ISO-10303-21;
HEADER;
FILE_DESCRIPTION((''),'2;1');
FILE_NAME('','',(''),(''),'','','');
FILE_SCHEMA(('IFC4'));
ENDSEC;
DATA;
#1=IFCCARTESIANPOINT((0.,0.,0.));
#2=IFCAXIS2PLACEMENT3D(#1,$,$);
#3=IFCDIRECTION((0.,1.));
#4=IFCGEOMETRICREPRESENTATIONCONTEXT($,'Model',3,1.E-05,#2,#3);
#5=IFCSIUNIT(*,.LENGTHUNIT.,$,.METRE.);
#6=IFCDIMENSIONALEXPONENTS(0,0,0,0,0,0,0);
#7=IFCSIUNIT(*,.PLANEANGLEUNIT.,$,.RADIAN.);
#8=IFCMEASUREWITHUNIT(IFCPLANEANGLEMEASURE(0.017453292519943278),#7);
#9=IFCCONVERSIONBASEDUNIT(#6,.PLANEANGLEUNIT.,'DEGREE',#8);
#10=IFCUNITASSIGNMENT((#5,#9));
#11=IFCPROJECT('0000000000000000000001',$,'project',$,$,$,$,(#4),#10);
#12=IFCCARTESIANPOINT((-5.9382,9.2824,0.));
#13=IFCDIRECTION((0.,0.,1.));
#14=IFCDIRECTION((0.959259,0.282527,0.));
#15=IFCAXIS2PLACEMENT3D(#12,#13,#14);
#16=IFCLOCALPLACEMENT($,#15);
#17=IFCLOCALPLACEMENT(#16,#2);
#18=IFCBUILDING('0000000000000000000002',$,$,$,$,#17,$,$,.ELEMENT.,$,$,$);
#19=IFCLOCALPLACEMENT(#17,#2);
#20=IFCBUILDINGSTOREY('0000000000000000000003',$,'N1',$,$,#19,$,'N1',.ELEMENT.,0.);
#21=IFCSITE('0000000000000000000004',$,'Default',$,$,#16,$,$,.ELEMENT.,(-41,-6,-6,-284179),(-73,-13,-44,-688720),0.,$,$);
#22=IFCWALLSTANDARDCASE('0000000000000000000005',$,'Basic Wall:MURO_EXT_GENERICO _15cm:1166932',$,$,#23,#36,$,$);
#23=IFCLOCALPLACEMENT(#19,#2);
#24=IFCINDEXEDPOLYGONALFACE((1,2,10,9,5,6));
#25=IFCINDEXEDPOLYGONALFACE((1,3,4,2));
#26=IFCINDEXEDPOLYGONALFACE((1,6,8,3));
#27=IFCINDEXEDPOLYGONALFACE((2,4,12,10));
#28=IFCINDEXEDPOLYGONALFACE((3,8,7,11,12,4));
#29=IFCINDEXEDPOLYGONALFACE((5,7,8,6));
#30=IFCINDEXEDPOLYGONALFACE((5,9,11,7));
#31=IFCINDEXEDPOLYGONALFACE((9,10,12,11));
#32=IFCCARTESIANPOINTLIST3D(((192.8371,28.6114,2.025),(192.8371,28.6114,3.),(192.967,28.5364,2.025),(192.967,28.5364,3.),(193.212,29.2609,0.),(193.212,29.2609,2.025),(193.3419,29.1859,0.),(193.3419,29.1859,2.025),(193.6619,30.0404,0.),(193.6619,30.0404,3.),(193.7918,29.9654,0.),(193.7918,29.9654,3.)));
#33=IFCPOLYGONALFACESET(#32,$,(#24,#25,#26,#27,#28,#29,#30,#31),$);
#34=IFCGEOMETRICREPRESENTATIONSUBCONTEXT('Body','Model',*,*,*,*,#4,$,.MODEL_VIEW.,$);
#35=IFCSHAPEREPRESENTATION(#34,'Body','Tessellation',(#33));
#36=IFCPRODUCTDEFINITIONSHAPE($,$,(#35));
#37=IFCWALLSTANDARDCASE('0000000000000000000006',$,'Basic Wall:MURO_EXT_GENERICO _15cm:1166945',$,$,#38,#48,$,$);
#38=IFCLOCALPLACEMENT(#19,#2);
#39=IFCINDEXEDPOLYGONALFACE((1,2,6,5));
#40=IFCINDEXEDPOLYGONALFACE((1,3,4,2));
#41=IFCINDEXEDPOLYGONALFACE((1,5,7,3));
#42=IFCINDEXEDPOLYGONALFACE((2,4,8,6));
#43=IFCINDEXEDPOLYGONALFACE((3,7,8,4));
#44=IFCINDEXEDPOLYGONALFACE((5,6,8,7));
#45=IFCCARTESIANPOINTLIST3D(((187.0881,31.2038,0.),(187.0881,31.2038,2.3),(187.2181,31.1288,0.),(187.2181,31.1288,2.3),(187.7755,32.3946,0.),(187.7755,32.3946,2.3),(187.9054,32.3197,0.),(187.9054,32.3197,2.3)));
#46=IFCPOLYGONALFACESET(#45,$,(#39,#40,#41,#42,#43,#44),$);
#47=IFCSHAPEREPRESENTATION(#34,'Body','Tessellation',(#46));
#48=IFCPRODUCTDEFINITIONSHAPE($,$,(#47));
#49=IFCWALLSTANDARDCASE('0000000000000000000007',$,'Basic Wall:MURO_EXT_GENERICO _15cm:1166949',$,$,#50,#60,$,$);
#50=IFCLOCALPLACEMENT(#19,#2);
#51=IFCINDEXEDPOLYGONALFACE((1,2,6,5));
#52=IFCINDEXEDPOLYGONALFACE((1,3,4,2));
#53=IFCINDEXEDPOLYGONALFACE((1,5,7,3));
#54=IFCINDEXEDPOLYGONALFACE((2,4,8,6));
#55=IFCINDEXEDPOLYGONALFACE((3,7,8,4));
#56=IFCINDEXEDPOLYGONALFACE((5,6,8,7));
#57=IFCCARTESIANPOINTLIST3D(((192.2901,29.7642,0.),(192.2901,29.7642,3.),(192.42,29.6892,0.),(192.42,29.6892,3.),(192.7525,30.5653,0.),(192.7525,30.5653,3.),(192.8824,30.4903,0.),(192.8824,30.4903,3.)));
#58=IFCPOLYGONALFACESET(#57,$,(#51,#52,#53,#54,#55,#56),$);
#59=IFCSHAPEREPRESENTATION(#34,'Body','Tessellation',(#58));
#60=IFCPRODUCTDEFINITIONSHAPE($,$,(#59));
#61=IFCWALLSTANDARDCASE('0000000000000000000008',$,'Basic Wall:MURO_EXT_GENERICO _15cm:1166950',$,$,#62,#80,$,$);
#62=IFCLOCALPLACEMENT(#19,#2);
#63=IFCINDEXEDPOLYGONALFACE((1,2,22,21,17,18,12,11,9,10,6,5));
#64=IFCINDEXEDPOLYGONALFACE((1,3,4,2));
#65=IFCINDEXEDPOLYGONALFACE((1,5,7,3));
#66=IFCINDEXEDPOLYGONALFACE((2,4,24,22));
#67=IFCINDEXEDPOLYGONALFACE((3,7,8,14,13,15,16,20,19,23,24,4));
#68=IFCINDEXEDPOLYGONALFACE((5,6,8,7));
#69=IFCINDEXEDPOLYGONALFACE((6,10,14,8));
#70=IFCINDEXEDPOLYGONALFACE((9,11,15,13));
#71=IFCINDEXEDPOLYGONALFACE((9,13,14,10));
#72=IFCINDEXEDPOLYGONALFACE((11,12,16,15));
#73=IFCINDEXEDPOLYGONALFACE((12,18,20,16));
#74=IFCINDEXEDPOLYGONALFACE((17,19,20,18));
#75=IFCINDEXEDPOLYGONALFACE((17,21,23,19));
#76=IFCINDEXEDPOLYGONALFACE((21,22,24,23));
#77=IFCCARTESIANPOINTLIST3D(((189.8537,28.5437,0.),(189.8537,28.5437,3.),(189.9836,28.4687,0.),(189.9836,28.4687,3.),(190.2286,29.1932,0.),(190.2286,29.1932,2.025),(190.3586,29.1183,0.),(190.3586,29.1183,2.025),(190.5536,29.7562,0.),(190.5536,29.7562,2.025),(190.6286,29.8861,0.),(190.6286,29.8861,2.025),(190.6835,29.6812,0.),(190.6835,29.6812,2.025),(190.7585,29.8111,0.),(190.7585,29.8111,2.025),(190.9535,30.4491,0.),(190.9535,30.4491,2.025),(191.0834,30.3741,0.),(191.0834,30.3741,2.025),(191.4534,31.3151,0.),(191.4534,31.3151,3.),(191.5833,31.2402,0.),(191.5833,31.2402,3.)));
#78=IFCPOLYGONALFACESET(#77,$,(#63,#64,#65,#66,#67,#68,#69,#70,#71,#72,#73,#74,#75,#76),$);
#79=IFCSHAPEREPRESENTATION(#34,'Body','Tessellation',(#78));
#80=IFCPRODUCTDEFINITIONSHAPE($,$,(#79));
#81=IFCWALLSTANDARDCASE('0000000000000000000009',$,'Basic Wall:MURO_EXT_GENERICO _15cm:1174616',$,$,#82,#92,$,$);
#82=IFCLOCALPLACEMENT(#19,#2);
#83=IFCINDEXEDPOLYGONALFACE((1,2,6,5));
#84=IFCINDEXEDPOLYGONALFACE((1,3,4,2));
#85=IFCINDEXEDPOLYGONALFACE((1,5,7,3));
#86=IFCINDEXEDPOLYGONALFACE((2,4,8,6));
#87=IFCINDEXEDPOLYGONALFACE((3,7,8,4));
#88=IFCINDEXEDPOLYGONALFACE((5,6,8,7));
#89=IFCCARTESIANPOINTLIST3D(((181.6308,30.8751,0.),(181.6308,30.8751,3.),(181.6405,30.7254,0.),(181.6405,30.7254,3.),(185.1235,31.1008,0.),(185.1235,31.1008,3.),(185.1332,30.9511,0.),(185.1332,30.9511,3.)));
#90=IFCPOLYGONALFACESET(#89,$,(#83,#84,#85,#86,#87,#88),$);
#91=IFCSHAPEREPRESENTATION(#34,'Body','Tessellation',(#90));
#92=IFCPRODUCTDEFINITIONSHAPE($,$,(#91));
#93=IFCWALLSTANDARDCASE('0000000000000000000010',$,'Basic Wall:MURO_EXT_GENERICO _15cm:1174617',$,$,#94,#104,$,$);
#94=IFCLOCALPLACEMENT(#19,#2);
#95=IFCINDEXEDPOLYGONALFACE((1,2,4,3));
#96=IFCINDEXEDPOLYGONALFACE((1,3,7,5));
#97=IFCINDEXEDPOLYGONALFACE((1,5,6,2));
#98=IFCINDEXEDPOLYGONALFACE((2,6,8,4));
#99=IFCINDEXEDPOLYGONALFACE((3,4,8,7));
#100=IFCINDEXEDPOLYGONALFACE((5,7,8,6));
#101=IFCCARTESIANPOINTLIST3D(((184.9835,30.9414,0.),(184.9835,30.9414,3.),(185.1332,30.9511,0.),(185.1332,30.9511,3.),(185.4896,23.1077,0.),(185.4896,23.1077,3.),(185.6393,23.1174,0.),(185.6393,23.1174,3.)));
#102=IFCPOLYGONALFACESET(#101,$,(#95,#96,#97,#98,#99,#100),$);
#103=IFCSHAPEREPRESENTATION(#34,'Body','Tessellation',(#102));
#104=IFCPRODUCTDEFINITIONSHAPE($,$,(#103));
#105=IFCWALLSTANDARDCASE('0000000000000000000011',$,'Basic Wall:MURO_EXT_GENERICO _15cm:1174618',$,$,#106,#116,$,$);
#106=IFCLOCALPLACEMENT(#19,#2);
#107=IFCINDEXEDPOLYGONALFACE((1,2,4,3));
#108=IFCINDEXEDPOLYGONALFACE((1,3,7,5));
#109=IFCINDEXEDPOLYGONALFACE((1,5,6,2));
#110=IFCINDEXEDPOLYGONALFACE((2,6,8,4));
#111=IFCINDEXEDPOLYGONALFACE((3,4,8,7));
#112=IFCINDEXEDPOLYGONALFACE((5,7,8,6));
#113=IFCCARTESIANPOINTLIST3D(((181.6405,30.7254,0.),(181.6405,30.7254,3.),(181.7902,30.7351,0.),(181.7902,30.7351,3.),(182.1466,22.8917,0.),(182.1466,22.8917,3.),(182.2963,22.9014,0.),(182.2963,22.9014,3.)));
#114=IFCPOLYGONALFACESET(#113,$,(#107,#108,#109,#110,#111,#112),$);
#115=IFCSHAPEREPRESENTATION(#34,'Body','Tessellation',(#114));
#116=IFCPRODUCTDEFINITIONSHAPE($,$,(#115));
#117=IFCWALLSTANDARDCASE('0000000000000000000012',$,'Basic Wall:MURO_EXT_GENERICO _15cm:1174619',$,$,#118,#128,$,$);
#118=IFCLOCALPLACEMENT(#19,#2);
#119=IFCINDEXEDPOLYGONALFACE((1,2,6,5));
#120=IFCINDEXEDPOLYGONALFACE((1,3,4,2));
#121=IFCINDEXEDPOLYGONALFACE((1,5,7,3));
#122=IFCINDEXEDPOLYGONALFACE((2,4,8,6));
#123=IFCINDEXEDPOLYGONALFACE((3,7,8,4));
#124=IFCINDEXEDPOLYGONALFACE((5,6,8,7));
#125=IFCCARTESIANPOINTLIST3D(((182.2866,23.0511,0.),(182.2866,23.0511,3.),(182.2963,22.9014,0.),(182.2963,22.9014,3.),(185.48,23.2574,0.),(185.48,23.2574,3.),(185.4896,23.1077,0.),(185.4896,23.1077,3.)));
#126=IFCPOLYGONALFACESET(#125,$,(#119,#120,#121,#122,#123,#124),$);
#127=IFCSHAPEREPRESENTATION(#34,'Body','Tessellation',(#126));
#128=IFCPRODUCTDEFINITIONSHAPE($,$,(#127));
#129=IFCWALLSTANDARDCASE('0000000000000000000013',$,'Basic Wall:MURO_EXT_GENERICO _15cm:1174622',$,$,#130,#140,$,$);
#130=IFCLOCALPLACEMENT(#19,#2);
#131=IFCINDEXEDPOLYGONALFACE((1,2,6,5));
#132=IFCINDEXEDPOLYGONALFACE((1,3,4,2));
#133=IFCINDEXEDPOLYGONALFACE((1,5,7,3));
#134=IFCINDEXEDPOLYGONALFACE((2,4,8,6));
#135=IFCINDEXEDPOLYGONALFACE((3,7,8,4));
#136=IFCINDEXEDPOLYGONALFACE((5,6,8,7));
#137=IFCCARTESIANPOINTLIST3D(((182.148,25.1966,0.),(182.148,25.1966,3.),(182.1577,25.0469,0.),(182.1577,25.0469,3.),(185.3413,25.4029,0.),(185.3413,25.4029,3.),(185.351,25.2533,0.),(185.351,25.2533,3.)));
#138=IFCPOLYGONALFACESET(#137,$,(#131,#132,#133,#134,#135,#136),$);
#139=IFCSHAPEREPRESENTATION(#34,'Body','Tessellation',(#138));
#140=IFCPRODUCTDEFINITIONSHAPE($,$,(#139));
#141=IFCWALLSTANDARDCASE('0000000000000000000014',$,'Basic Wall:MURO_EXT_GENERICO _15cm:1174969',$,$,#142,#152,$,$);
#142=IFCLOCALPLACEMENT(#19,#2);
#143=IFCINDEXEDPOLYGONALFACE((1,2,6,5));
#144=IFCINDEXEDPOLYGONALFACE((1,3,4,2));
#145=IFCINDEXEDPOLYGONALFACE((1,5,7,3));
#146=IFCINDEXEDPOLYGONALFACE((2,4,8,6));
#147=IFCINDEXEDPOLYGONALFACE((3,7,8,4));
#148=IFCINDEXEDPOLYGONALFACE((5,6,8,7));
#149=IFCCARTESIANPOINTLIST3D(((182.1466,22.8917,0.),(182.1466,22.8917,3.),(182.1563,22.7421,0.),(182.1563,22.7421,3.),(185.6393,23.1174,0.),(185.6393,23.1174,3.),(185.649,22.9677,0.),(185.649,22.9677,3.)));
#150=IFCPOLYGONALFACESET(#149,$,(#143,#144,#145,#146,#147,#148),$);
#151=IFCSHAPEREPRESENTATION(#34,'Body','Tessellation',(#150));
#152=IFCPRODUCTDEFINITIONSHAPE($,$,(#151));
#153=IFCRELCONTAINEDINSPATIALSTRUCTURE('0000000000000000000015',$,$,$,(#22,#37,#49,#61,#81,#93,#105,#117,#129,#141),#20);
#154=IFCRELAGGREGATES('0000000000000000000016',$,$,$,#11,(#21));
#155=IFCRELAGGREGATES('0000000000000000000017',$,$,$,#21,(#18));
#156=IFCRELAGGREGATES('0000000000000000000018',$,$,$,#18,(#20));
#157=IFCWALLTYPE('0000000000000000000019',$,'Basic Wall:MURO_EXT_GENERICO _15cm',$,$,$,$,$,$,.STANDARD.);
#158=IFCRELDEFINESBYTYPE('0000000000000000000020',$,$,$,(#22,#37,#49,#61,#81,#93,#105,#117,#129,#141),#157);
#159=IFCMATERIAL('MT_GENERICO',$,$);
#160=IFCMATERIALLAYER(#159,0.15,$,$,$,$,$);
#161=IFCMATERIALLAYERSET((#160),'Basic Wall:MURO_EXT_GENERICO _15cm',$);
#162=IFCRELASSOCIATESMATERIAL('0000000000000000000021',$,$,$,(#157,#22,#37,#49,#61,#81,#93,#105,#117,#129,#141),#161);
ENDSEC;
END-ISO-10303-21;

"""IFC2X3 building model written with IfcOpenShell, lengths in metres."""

from ifc_helpers import new_model, entity, si_unit, converted_unit, direction, frame, frame_2d, origin, place, context, subcontext, project, spatial, rectangle, extrude, material, layer, layer_set, layer_usage, type_object, element, save


model = new_model("IFC2X3")

# Units and contexts
model_context = context("Model", 3, precision=1e-05, world=origin(), true_north=direction((0.0, 1.0)))
body_context = subcontext(model_context, "Body", "Model", "MODEL_VIEW")
ifc_project = project(units=[si_unit("LENGTHUNIT", "METRE"), converted_unit("PLANEANGLEUNIT", "DEGREE", entity("IfcPlaneAngleMeasure", 0.017453292519943278), si_unit("PLANEANGLEUNIT", "RADIAN"), dimensions=[0, 0, 0, 0, 0, 0, 0])], contexts=[model_context])

# Site, building, storey
site_placement = place(None, frame((-5.9382, 9.2824, 0.0), z_axis=(0.0, 0.0, 1.0), x_axis=(0.959259, 0.282527, 0.0)))
site = spatial("IfcSite", under=ifc_project, at=site_placement, Name="Default", CompositionType="ELEMENT", RefLatitude=(-41, -6, -6, -284179), RefLongitude=(-73, -13, -44, -688720), RefElevation=0.0)
building_placement = place(site_placement, origin())
building = spatial("IfcBuilding", under=site, at=building_placement, CompositionType="ELEMENT")
storey_placement = place(building_placement, origin())
storey = spatial("IfcBuildingStorey", under=building, at=storey_placement, Name="N1", LongName="N1", CompositionType="ELEMENT", Elevation=0.0)

# Shared definitions
ifc_material_1 = material(Name="MT_GENERICO")

# Shared definitions
ifc_layer_1 = layer(ifc_material_1, 0.15)
ifc_layer_set_1 = layer_set([ifc_layer_1], Name="Basic Wall:MURO_EXT_GENERICO _15cm")
wall_type_1 = type_object("IfcWallType", Name="Basic Wall:MURO_EXT_GENERICO _15cm", PredefinedType="STANDARD", material=ifc_layer_set_1)

# Wall, opening
ifc_layer_usage_1 = layer_usage(ifc_layer_set_1, "AXIS2", "NEGATIVE", 0.075)
wall_1_placement = place(storey_placement, frame((192.902, 28.5739, 0.0), z_axis=(0.0, 0.0, 1.0), x_axis=(0.499903, 0.866082, 0.0)))
wall_1 = element("IfcWallStandardCase", 1, at=wall_1_placement, inside=storey, type_object=wall_type_1, material=ifc_layer_usage_1, Name="Basic Wall:MURO_EXT_GENERICO _15cm:1166932", context=body_context, shape_type="SweptSolid", body=[
    extrude(rectangle(XDim=1.65, YDim=0.15, at=frame_2d((0.825, 0.0), x_axis=(-1.0, 0.0))), origin(), (0.0, 0.0, 1.0), 3.0),
])
opening_1_placement = place(wall_1_placement, frame((0.0, -0.075, 0.0)))
element("IfcOpeningElement", 2, at=opening_1_placement, cuts=wall_1, ObjectType="Opening", context=body_context, shape_type="SweptSolid", body=[
    extrude(rectangle(XDim=2.025, YDim=0.75, at=frame_2d((1.0125, 0.375), x_axis=(1.0, 0.0))), frame((0.0, 0.0, 0.0), z_axis=(0.0, 1.0, 0.0), x_axis=(0.0, 0.0, 1.0)), (0.0, 0.0, 1.0), 0.15),
])

# Walls
ifc_layer_usage_2 = layer_usage(ifc_layer_set_1, "AXIS2", "NEGATIVE", 0.075)
wall_2_placement = place(storey_placement, frame((187.1531, 31.1663, 0.0), z_axis=(0.0, 0.0, 1.0), x_axis=(0.499903, 0.866082, 0.0)))
element("IfcWallStandardCase", 3, at=wall_2_placement, inside=storey, type_object=wall_type_1, material=ifc_layer_usage_2, Name="Basic Wall:MURO_EXT_GENERICO _15cm:1166945", context=body_context, shape_type="SweptSolid", body=[
    extrude(rectangle(XDim=1.375, YDim=0.15, at=frame_2d((0.6875, 0.0), x_axis=(-1.0, 0.0))), origin(), (0.0, 0.0, 1.0), 2.3),
])
ifc_layer_usage_3 = layer_usage(ifc_layer_set_1, "AXIS2", "NEGATIVE", 0.075)
wall_3_placement = place(storey_placement, frame((192.8175, 30.5278, 0.0), z_axis=(0.0, 0.0, 1.0), x_axis=(-0.499903, -0.866082, 0.0)))
element("IfcWallStandardCase", 4, at=wall_3_placement, inside=storey, type_object=wall_type_1, material=ifc_layer_usage_3, Name="Basic Wall:MURO_EXT_GENERICO _15cm:1166949", context=body_context, shape_type="SweptSolid", body=[
    extrude(rectangle(XDim=0.925, YDim=0.15, at=frame_2d((0.4625, 0.0), x_axis=(-1.0, 0.0))), origin(), (0.0, 0.0, 1.0), 3.0),
])

# Wall, openings
ifc_layer_usage_4 = layer_usage(ifc_layer_set_1, "AXIS2", "NEGATIVE", 0.075)
wall_4_placement = place(storey_placement, frame((191.5184, 31.2777, 0.0), z_axis=(0.0, 0.0, 1.0), x_axis=(-0.499903, -0.866082, 0.0)))
wall_4 = element("IfcWallStandardCase", 5, at=wall_4_placement, inside=storey, type_object=wall_type_1, material=ifc_layer_usage_4, Name="Basic Wall:MURO_EXT_GENERICO _15cm:1166950", context=body_context, shape_type="SweptSolid", body=[
    extrude(rectangle(XDim=3.2, YDim=0.15, at=frame_2d((1.6, 0.0), x_axis=(-1.0, 0.0))), origin(), (0.0, 0.0, 1.0), 3.0),
])
opening_2_placement = place(wall_4_placement, frame((1.0, -0.075, 0.0)))
element("IfcOpeningElement", 6, at=opening_2_placement, cuts=wall_4, ObjectType="Opening", context=body_context, shape_type="SweptSolid", body=[
    extrude(rectangle(XDim=2.025, YDim=0.65, at=frame_2d((1.0125, 0.325), x_axis=(1.0, 0.0))), frame((0.0, 0.0, 0.0), z_axis=(0.0, 1.0, 0.0), x_axis=(0.0, 0.0, 1.0)), (0.0, 0.0, 1.0), 0.15),
])
opening_3_placement = place(wall_4_placement, frame((1.8, -0.075, 0.0)))
element("IfcOpeningElement", 7, at=opening_3_placement, cuts=wall_4, ObjectType="Opening", context=body_context, shape_type="SweptSolid", body=[
    extrude(rectangle(XDim=2.025, YDim=0.65, at=frame_2d((1.0125, 0.325), x_axis=(1.0, 0.0))), frame((0.0, 0.0, 0.0), z_axis=(0.0, 1.0, 0.0), x_axis=(0.0, 0.0, 1.0)), (0.0, 0.0, 1.0), 0.15),
])

# Walls
ifc_layer_usage_5 = layer_usage(ifc_layer_set_1, "AXIS2", "POSITIVE", -0.075)
wall_5_placement = place(storey_placement, frame((181.6357, 30.8003, 0.0), z_axis=(0.0, 0.0, 1.0), x_axis=(0.99792, 0.064471, 0.0)))
element("IfcWallStandardCase", 8, at=wall_5_placement, inside=storey, type_object=wall_type_1, material=ifc_layer_usage_5, Name="Basic Wall:MURO_EXT_GENERICO _15cm:1174616", context=body_context, shape_type="SweptSolid", body=[
    extrude(rectangle(XDim=3.5, YDim=0.15, at=frame_2d((1.75, 0.0), x_axis=(-1.0, 0.0))), origin(), (0.0, 0.0, 1.0), 3.0),
])
ifc_layer_usage_6 = layer_usage(ifc_layer_set_1, "AXIS2", "POSITIVE", -0.075)
wall_6_placement = place(storey_placement, frame((185.0584, 30.9462, 0.0), z_axis=(0.0, 0.0, 1.0), x_axis=(0.064471, -0.99792, 0.0)))
element("IfcWallStandardCase", 9, at=wall_6_placement, inside=storey, type_object=wall_type_1, material=ifc_layer_usage_6, Name="Basic Wall:MURO_EXT_GENERICO _15cm:1174617", context=body_context, shape_type="SweptSolid", body=[
    extrude(rectangle(XDim=7.85, YDim=0.15, at=frame_2d((3.925, 0.0), x_axis=(-1.0, 0.0))), origin(), (0.0, 0.0, 1.0), 3.0),
])
ifc_layer_usage_7 = layer_usage(ifc_layer_set_1, "AXIS2", "POSITIVE", -0.075)
wall_7_placement = place(storey_placement, frame((182.2214, 22.8966, 0.0), z_axis=(0.0, 0.0, 1.0), x_axis=(-0.064471, 0.99792, 0.0)))
element("IfcWallStandardCase", 10, at=wall_7_placement, inside=storey, type_object=wall_type_1, material=ifc_layer_usage_7, Name="Basic Wall:MURO_EXT_GENERICO _15cm:1174618", context=body_context, shape_type="SweptSolid", body=[
    extrude(rectangle(XDim=7.85, YDim=0.15, at=frame_2d((3.925, 0.0), x_axis=(-1.0, 0.0))), origin(), (0.0, 0.0, 1.0), 3.0),
])
ifc_layer_usage_8 = layer_usage(ifc_layer_set_1, "AXIS2", "POSITIVE", -0.075)
wall_8_placement = place(storey_placement, frame((185.4848, 23.1826, 0.0), z_axis=(0.0, 0.0, 1.0), x_axis=(-0.99792, -0.064471, 0.0)))
element("IfcWallStandardCase", 11, at=wall_8_placement, inside=storey, type_object=wall_type_1, material=ifc_layer_usage_8, Name="Basic Wall:MURO_EXT_GENERICO _15cm:1174619", context=body_context, shape_type="SweptSolid", body=[
    extrude(rectangle(XDim=3.2, YDim=0.15, at=frame_2d((1.6, 0.0), x_axis=(-1.0, 0.0))), origin(), (0.0, 0.0, 1.0), 3.0),
])
ifc_layer_usage_9 = layer_usage(ifc_layer_set_1, "AXIS2", "POSITIVE", -0.075)
wall_9_placement = place(storey_placement, frame((185.3462, 25.3281, 0.0), z_axis=(0.0, 0.0, 1.0), x_axis=(-0.99792, -0.064471, 0.0)))
element("IfcWallStandardCase", 12, at=wall_9_placement, inside=storey, type_object=wall_type_1, material=ifc_layer_usage_9, Name="Basic Wall:MURO_EXT_GENERICO _15cm:1174622", context=body_context, shape_type="SweptSolid", body=[
    extrude(rectangle(XDim=3.2, YDim=0.15, at=frame_2d((1.6, 0.0), x_axis=(-1.0, 0.0))), origin(), (0.0, 0.0, 1.0), 3.0),
])
ifc_layer_usage_10 = layer_usage(ifc_layer_set_1, "AXIS2", "POSITIVE", -0.075)
wall_10_placement = place(storey_placement, frame((182.1514, 22.8169, 0.0), z_axis=(0.0, 0.0, 1.0), x_axis=(0.99792, 0.064471, 0.0)))
element("IfcWallStandardCase", 13, at=wall_10_placement, inside=storey, type_object=wall_type_1, material=ifc_layer_usage_10, Name="Basic Wall:MURO_EXT_GENERICO _15cm:1174969", context=body_context, shape_type="SweptSolid", body=[
    extrude(rectangle(XDim=3.5, YDim=0.15, at=frame_2d((1.75, 0.0), x_axis=(-1.0, 0.0))), origin(), (0.0, 0.0, 1.0), 3.0),
])

save(model, "model.ifc")
